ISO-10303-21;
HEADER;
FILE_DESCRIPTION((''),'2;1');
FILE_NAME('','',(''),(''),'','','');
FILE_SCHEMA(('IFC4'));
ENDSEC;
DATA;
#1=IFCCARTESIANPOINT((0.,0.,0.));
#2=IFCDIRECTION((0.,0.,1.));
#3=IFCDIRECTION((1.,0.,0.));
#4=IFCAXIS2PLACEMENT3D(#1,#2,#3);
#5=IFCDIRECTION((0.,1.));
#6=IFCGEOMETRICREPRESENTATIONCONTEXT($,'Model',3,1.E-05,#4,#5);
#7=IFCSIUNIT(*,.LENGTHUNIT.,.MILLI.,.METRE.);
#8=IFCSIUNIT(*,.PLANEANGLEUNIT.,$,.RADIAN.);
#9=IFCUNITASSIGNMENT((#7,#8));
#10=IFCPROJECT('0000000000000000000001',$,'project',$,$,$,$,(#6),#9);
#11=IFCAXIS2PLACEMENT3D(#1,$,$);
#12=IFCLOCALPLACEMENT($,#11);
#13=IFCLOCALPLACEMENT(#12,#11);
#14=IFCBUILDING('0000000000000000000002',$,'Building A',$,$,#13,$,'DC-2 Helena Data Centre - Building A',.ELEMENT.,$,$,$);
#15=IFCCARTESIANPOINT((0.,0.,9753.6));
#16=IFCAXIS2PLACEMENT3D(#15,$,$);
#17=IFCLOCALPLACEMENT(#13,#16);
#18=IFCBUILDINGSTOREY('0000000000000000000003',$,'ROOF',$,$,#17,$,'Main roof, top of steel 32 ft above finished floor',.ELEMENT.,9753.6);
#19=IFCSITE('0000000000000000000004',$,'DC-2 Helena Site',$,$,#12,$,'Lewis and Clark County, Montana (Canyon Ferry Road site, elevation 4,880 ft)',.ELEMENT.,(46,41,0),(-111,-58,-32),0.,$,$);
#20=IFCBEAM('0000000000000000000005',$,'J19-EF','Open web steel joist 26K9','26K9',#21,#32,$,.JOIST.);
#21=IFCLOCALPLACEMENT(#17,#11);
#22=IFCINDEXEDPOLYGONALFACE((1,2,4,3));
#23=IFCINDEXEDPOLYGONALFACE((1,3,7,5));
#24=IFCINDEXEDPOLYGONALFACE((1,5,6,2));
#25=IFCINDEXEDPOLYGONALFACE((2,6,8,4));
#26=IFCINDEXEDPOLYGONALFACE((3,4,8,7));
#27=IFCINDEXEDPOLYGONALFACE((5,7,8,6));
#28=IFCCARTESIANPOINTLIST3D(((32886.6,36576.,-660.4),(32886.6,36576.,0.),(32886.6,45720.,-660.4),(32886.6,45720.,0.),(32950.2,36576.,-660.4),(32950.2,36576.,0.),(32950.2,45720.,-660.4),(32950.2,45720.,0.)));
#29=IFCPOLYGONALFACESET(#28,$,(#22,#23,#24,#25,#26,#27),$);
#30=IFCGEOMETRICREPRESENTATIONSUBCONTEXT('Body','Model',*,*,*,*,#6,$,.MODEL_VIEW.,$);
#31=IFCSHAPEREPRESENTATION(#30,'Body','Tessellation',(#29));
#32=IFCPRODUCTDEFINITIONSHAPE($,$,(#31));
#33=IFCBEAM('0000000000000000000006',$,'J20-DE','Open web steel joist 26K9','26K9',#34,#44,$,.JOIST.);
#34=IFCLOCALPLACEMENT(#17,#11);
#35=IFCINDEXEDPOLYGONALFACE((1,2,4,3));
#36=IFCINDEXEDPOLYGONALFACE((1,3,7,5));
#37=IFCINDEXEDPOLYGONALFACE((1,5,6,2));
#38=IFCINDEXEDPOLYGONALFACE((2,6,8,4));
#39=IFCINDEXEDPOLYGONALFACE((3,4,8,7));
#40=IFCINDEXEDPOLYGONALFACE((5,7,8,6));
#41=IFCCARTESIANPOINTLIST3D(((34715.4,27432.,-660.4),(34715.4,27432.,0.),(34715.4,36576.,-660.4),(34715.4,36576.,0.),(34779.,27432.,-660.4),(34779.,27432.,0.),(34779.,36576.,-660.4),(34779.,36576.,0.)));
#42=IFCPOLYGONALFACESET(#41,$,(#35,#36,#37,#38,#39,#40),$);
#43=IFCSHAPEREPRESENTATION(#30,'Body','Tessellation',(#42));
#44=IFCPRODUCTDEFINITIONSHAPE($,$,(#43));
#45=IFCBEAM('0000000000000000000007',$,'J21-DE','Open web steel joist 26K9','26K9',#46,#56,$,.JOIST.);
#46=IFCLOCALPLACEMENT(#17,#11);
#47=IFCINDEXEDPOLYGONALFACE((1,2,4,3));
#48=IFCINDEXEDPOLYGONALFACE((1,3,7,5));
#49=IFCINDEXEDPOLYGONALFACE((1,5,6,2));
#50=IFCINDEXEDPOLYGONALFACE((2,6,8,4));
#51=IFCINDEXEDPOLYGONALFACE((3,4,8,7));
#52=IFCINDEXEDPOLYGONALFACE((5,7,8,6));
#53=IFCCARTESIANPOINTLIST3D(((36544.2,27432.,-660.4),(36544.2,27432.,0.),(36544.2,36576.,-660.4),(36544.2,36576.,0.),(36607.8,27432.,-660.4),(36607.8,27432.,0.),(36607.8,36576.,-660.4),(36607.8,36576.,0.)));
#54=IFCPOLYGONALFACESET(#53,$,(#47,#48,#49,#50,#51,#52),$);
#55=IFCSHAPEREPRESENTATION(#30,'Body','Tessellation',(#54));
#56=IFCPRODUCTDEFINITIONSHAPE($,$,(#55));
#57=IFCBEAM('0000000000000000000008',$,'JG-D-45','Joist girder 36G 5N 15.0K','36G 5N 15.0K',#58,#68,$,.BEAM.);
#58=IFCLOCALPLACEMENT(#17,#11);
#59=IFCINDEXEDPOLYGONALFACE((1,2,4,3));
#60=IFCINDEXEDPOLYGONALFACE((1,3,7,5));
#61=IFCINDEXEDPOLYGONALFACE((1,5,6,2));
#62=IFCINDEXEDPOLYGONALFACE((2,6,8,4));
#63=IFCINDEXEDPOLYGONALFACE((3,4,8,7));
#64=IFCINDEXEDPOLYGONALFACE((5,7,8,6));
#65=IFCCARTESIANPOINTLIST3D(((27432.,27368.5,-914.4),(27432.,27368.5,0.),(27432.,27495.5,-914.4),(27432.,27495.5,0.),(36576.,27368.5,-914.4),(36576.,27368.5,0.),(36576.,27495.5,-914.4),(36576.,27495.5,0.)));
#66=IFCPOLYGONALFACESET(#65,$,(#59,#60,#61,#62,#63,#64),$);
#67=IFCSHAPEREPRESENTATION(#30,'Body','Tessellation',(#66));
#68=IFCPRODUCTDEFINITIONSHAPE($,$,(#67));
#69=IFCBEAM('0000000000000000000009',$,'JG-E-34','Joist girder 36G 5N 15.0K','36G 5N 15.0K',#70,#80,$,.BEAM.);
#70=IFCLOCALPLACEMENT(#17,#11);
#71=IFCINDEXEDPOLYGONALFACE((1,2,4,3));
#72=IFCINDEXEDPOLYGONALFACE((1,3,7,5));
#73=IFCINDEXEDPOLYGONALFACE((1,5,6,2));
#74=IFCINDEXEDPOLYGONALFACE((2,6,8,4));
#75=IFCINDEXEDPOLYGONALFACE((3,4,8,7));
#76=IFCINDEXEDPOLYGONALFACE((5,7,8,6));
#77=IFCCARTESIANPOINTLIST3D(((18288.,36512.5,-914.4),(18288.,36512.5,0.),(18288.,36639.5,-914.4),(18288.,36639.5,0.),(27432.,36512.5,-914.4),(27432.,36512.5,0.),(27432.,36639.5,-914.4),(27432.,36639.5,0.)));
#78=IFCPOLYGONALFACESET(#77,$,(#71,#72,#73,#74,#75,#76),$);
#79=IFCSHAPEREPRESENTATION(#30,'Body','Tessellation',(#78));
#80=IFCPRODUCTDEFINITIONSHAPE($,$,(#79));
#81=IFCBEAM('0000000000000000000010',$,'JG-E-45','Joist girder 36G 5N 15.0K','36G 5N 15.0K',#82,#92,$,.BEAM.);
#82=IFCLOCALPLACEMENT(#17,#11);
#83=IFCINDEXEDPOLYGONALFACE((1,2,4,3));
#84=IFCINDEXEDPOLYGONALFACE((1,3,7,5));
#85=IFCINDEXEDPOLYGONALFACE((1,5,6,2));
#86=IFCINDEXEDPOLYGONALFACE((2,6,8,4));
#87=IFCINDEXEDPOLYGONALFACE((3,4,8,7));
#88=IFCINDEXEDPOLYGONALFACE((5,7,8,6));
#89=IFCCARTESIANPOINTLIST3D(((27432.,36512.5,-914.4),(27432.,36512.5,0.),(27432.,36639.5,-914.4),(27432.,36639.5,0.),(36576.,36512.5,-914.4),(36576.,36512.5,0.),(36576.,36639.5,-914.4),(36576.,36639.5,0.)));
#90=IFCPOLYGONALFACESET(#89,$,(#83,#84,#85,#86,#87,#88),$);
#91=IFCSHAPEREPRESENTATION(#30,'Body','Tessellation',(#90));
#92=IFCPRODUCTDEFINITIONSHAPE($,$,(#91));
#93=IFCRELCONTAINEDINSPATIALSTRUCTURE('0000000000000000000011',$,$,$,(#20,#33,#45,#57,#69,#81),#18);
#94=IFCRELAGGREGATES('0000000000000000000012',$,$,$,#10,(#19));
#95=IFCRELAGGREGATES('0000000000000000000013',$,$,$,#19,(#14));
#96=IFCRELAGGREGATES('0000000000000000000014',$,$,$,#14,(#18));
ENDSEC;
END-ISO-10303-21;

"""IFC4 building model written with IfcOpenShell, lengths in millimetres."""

from ifc_helpers import new_model, si_unit, direction, frame, origin, origin_with_axes, origin_2d, place, context, subcontext, project, spatial, rectangle, extrude, element, save


model = new_model("IFC4")

# Units and contexts
model_context = context("Model", 3, precision=1e-05, world=origin_with_axes(), true_north=direction((0.0, 1.0)))
body_context = subcontext(model_context, "Body", "Model", "MODEL_VIEW")
ifc_project = project(units=[si_unit("LENGTHUNIT", "METRE", prefix="MILLI"), si_unit("PLANEANGLEUNIT", "RADIAN")], contexts=[model_context])

# Site, building, storey
site_placement = place(None, origin())
site = spatial("IfcSite", under=ifc_project, at=site_placement, Name="DC-2 Helena Site", LongName="Lewis and Clark County, Montana (Canyon Ferry Road site, elevation 4,880 ft)", CompositionType="ELEMENT", RefLatitude=(46, 41, 0), RefLongitude=(-111, -58, -32), RefElevation=0.0)
building_placement = place(site_placement, origin())
building = spatial("IfcBuilding", under=site, at=building_placement, Name="Building A", LongName="DC-2 Helena Data Centre - Building A", CompositionType="ELEMENT")
storey_placement = place(building_placement, frame((0.0, 0.0, 9753.6)))
storey = spatial("IfcBuildingStorey", under=building, at=storey_placement, Name="ROOF", LongName="Main roof, top of steel 32 ft above finished floor", CompositionType="ELEMENT", Elevation=9753.6)

# Beams
placement_1 = place(storey_placement, frame((18288.0, 36576.0, 0.0)))
placement_2 = place(storey_placement, frame((27432.0, 27432.0, 0.0)))
placement_3 = place(storey_placement, frame((27432.0, 36576.0, 0.0)))
for number, where, name in (
    (1, (32918.4, 36576.0, 0.0), "J19-EF"),
    (2, (34747.2, 27432.0, 0.0), "J20-DE"),
):
    element("IfcBeam", number, at=place(storey_placement, frame(where)), inside=storey, Name=name, Description="Open web steel joist 26K9", ObjectType="26K9", PredefinedType="JOIST", context=body_context, shape_type="SweptSolid", body=[
        extrude(rectangle(XDim=63.5, YDim=660.4, at=origin_2d()), frame((0.0, 0.0, -330.2), z_axis=(0.0, 1.0, 0.0), x_axis=(1.0, 0.0, 0.0)), (0.0, 0.0, 1.0), 9144.0),
    ])
beam_1_placement = place(storey_placement, frame((36576.0, 27432.0, 0.0)))
element("IfcBeam", 3, at=beam_1_placement, inside=storey, Name="J21-DE", Description="Open web steel joist 26K9", ObjectType="26K9", PredefinedType="JOIST", context=body_context, shape_type="SweptSolid", body=[
    extrude(rectangle(XDim=63.5, YDim=660.4, at=origin_2d()), frame((0.0, 0.0, -330.2), z_axis=(0.0, 1.0, 0.0), x_axis=(1.0, 0.0, 0.0)), (0.0, 0.0, 1.0), 9144.0),
])
element("IfcBeam", 4, at=placement_2, inside=storey, Name="JG-D-45", Description="Joist girder 36G 5N 15.0K", ObjectType="36G 5N 15.0K", PredefinedType="BEAM", context=body_context, shape_type="SweptSolid", body=[
    extrude(rectangle(XDim=127.0, YDim=914.4, at=origin_2d()), frame((0.0, 0.0, -457.2), z_axis=(1.0, 0.0, 0.0), x_axis=(0.0, 1.0, 0.0)), (0.0, 0.0, 1.0), 9144.0),
])
element("IfcBeam", 5, at=placement_1, inside=storey, Name="JG-E-34", Description="Joist girder 36G 5N 15.0K", ObjectType="36G 5N 15.0K", PredefinedType="BEAM", context=body_context, shape_type="SweptSolid", body=[
    extrude(rectangle(XDim=127.0, YDim=914.4, at=origin_2d()), frame((0.0, 0.0, -457.2), z_axis=(1.0, 0.0, 0.0), x_axis=(0.0, 1.0, 0.0)), (0.0, 0.0, 1.0), 9144.0),
])
element("IfcBeam", 6, at=placement_3, inside=storey, Name="JG-E-45", Description="Joist girder 36G 5N 15.0K", ObjectType="36G 5N 15.0K", PredefinedType="BEAM", context=body_context, shape_type="SweptSolid", body=[
    extrude(rectangle(XDim=127.0, YDim=914.4, at=origin_2d()), frame((0.0, 0.0, -457.2), z_axis=(1.0, 0.0, 0.0), x_axis=(0.0, 1.0, 0.0)), (0.0, 0.0, 1.0), 9144.0),
])

save(model, "model.ifc")
